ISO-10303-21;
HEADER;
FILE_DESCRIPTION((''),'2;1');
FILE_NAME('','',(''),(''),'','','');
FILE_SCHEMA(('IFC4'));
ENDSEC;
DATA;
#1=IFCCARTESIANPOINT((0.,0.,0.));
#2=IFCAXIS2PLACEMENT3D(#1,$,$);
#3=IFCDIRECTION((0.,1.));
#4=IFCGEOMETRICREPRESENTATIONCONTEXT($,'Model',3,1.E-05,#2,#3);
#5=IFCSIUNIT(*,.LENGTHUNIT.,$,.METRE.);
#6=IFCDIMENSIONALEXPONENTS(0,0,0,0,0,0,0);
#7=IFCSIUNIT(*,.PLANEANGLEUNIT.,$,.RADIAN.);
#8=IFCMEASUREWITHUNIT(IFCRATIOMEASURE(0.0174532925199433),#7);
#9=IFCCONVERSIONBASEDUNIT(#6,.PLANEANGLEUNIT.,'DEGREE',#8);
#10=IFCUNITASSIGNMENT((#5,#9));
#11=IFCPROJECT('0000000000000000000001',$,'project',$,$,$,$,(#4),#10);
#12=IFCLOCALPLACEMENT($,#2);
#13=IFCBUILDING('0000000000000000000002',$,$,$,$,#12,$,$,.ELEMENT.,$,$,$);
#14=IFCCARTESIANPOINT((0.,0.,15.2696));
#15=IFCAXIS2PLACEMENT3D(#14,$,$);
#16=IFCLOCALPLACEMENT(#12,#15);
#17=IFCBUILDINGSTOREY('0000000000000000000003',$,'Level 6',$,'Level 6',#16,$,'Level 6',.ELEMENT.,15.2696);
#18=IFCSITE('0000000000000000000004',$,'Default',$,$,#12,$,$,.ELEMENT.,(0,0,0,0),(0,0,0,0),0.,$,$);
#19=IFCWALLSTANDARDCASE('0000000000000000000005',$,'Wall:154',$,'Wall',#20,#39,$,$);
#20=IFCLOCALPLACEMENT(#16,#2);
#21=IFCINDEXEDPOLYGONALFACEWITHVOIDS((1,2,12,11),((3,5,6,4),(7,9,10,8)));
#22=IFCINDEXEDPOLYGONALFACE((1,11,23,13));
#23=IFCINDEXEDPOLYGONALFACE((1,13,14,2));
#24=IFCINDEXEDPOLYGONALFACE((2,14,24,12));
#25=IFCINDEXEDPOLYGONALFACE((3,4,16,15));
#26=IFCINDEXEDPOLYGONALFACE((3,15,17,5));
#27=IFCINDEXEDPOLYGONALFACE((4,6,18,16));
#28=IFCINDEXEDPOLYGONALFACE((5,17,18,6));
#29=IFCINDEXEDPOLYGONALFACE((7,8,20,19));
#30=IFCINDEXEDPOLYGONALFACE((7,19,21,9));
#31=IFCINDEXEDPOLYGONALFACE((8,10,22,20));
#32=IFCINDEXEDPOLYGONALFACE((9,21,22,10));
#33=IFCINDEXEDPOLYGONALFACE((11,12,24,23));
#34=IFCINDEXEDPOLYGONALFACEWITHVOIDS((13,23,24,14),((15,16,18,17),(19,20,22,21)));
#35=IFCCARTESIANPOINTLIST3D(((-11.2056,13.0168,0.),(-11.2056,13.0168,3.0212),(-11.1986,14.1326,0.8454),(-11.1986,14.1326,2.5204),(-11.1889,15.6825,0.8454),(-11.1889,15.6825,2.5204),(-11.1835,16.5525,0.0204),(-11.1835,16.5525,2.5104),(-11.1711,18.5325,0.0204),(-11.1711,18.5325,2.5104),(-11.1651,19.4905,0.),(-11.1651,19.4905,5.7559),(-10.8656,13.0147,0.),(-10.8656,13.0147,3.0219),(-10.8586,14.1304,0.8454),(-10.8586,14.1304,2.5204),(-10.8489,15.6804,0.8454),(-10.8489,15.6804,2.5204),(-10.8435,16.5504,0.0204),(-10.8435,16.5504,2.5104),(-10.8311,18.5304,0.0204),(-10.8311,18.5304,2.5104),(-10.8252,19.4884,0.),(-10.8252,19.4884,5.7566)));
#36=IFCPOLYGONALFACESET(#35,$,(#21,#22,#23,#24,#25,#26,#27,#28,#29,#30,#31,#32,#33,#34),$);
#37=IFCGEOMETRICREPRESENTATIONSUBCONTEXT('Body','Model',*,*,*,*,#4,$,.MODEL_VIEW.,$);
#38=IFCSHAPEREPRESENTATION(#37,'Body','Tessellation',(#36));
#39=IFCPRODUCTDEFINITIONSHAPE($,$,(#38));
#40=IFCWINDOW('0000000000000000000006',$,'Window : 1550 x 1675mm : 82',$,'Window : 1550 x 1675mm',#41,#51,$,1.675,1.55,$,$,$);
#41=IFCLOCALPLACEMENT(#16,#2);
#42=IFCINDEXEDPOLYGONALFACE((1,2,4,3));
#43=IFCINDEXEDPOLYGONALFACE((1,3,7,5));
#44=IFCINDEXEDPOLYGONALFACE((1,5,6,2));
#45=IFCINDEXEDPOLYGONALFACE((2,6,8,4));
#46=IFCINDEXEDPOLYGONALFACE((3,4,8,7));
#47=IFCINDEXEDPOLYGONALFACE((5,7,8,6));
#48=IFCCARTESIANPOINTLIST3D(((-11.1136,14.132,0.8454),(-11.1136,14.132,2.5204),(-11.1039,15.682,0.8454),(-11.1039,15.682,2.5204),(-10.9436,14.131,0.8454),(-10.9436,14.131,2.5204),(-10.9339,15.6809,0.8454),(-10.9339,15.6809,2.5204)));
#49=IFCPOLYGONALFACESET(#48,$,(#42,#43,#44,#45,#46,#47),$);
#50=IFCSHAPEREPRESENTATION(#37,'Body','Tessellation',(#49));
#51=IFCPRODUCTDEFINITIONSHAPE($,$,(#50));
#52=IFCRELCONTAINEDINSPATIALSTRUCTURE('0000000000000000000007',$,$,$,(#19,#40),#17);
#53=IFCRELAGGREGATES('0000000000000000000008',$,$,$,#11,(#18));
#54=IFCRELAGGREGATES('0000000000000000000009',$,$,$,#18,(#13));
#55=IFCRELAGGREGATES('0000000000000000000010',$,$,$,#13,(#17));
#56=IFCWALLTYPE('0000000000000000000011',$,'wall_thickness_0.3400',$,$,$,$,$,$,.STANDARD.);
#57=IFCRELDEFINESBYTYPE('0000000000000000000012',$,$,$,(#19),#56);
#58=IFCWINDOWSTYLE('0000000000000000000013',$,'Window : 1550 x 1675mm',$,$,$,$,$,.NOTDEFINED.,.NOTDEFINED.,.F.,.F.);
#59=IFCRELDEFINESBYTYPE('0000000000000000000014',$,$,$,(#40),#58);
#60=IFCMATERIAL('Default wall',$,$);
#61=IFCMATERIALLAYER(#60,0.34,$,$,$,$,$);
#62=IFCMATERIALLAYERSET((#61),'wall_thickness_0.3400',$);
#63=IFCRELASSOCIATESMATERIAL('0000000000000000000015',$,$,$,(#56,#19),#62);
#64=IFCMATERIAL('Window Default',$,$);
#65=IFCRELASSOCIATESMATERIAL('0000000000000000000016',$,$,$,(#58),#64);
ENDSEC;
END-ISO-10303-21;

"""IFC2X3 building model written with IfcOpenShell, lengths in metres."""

from ifc_helpers import new_model, entity, si_unit, converted_unit, direction, frame, frame_2d, origin, origin_2d_with_axis, place, context, subcontext, project, spatial, polyline, rectangle, outline, extrude, clip, halfspace, source, transform, mapped, material, layer, layer_set, layer_usage, type_object, type_shapes, element, fill, save


model = new_model("IFC2X3")

# Units and contexts
model_context = context("Model", 3, precision=1e-05, world=origin(), true_north=direction((0.0, 1.0)))
body_context = subcontext(model_context, "Body", "Model", "MODEL_VIEW")
ifc_project = project(units=[si_unit("LENGTHUNIT", "METRE"), converted_unit("PLANEANGLEUNIT", "DEGREE", entity("IfcRatioMeasure", 0.0174532925199433), si_unit("PLANEANGLEUNIT", "RADIAN"), dimensions=[0, 0, 0, 0, 0, 0, 0])], contexts=[model_context])

# Site, building, storey
placement = place(None, origin())
site = spatial("IfcSite", under=ifc_project, at=placement, Name="Default", CompositionType="ELEMENT", RefLatitude=(0, 0, 0, 0), RefLongitude=(0, 0, 0, 0), RefElevation=0.0)
building = spatial("IfcBuilding", under=site, at=placement, CompositionType="ELEMENT")
storey_placement = place(placement, frame((0.0, 0.0, 15.2696)))
storey = spatial("IfcBuildingStorey", under=building, at=storey_placement, Name="Level 6", ObjectType="Level 6", LongName="Level 6", CompositionType="ELEMENT", Elevation=15.2696)

# Shared definitions
ifc_material_1 = material(Name="Default wall")

# Shared definitions
ifc_material_2 = material(Name="Window Default")

# Wall, openings, window
ifc_layer_1 = layer(ifc_material_1, 0.34)
ifc_layer_set_1 = layer_set([ifc_layer_1], Name="wall_thickness_0.3400")
ifc_layer_usage_1 = layer_usage(ifc_layer_set_1, "AXIS2", "POSITIVE", -0.17)
wall_type_1 = type_object("IfcWallType", Name="wall_thickness_0.3400", PredefinedType="STANDARD", material=ifc_layer_set_1)
wall_1_placement = place(storey_placement, frame((-10.9952, 19.4894, 0.0), z_axis=(0.0, 0.0, 1.0), x_axis=(-0.006241, -0.999981, 0.0)))
wall_1 = element("IfcWallStandardCase", 1, at=wall_1_placement, inside=storey, type_object=wall_type_1, material=ifc_layer_usage_1, Name="Wall:154", ObjectType="Wall", context=body_context, shape_type="Clipping", body=[
    clip(extrude(outline(polyline([(6.4738, -0.17), (6.4738, 0.17), (0.0, 0.17), (0.0, -0.17), (6.4738, -0.17)])), origin(), (0.0, 0.0, 1.0), 5.8304), halfspace(frame((-0.098, -1.0386, 5.7956), z_axis=(0.389137, -0.001865, 0.921178), x_axis=(0.003565, 0.999994, 0.000518)), False)),
])
opening_1_placement = place(wall_1_placement, frame((0.958, -0.17, 0.0204)))
element("IfcOpeningElement", 2, at=opening_1_placement, cuts=wall_1, ObjectType="Opening", context=body_context, shape_type="SweptSolid", body=[
    extrude(rectangle(XDim=1.98, YDim=2.49, at=frame_2d((1.245, 0.99), x_axis=(0.0, 1.0))), frame((0.0, 0.0, 0.0), z_axis=(0.0, 1.0, 0.0), x_axis=(0.0, 0.0, 1.0)), (0.0, 0.0, 1.0), 0.34),
])
opening_2_placement = place(wall_1_placement, frame((3.808, -0.17, 0.8454)))
opening_2 = element("IfcOpeningElement", 3, at=opening_2_placement, cuts=wall_1, ObjectType="Opening", context=body_context, shape_type="SweptSolid", body=[
    extrude(rectangle(XDim=1.55, YDim=1.675, at=frame_2d((0.8375, 0.775), x_axis=(0.0, 1.0))), frame((0.0, 0.0, 0.0), z_axis=(0.0, 1.0, 0.0), x_axis=(0.0, 0.0, 1.0)), (0.0, 0.0, 1.0), 0.34),
])
window_style_1 = type_object("IfcWindowStyle", Name="Window : 1550 x 1675mm", ConstructionType="NOTDEFINED", OperationType="NOTDEFINED", ParameterTakesPrecedence=False, Sizeable=False, material=ifc_material_2)
shared_shape_1 = source(origin(), body_context, "Body", "SweptSolid", [
    extrude(rectangle(XDim=0.17, YDim=1.55, at=origin_2d_with_axis()), frame((0.775, 0.17, 0.0), z_axis=(0.0, 0.0, 1.0), x_axis=(0.0, 1.0, 0.0)), (0.0, 0.0, 1.0), 1.675),
])
type_shapes(window_style_1, [shared_shape_1])
window_1_placement = place(opening_2_placement, origin())
window_1 = element("IfcWindow", 4, at=window_1_placement, inside=storey, type_object=window_style_1, Name="Window : 1550 x 1675mm : 82", ObjectType="Window : 1550 x 1675mm", OverallHeight=1.675, OverallWidth=1.55, context=body_context, shape_type="MappedRepresentation", body=[
    mapped(shared_shape_1, transform((0.0, 0.0, 0.0), scale=1.0)),
])
fill(opening_2, window_1)

save(model, "model.ifc")
